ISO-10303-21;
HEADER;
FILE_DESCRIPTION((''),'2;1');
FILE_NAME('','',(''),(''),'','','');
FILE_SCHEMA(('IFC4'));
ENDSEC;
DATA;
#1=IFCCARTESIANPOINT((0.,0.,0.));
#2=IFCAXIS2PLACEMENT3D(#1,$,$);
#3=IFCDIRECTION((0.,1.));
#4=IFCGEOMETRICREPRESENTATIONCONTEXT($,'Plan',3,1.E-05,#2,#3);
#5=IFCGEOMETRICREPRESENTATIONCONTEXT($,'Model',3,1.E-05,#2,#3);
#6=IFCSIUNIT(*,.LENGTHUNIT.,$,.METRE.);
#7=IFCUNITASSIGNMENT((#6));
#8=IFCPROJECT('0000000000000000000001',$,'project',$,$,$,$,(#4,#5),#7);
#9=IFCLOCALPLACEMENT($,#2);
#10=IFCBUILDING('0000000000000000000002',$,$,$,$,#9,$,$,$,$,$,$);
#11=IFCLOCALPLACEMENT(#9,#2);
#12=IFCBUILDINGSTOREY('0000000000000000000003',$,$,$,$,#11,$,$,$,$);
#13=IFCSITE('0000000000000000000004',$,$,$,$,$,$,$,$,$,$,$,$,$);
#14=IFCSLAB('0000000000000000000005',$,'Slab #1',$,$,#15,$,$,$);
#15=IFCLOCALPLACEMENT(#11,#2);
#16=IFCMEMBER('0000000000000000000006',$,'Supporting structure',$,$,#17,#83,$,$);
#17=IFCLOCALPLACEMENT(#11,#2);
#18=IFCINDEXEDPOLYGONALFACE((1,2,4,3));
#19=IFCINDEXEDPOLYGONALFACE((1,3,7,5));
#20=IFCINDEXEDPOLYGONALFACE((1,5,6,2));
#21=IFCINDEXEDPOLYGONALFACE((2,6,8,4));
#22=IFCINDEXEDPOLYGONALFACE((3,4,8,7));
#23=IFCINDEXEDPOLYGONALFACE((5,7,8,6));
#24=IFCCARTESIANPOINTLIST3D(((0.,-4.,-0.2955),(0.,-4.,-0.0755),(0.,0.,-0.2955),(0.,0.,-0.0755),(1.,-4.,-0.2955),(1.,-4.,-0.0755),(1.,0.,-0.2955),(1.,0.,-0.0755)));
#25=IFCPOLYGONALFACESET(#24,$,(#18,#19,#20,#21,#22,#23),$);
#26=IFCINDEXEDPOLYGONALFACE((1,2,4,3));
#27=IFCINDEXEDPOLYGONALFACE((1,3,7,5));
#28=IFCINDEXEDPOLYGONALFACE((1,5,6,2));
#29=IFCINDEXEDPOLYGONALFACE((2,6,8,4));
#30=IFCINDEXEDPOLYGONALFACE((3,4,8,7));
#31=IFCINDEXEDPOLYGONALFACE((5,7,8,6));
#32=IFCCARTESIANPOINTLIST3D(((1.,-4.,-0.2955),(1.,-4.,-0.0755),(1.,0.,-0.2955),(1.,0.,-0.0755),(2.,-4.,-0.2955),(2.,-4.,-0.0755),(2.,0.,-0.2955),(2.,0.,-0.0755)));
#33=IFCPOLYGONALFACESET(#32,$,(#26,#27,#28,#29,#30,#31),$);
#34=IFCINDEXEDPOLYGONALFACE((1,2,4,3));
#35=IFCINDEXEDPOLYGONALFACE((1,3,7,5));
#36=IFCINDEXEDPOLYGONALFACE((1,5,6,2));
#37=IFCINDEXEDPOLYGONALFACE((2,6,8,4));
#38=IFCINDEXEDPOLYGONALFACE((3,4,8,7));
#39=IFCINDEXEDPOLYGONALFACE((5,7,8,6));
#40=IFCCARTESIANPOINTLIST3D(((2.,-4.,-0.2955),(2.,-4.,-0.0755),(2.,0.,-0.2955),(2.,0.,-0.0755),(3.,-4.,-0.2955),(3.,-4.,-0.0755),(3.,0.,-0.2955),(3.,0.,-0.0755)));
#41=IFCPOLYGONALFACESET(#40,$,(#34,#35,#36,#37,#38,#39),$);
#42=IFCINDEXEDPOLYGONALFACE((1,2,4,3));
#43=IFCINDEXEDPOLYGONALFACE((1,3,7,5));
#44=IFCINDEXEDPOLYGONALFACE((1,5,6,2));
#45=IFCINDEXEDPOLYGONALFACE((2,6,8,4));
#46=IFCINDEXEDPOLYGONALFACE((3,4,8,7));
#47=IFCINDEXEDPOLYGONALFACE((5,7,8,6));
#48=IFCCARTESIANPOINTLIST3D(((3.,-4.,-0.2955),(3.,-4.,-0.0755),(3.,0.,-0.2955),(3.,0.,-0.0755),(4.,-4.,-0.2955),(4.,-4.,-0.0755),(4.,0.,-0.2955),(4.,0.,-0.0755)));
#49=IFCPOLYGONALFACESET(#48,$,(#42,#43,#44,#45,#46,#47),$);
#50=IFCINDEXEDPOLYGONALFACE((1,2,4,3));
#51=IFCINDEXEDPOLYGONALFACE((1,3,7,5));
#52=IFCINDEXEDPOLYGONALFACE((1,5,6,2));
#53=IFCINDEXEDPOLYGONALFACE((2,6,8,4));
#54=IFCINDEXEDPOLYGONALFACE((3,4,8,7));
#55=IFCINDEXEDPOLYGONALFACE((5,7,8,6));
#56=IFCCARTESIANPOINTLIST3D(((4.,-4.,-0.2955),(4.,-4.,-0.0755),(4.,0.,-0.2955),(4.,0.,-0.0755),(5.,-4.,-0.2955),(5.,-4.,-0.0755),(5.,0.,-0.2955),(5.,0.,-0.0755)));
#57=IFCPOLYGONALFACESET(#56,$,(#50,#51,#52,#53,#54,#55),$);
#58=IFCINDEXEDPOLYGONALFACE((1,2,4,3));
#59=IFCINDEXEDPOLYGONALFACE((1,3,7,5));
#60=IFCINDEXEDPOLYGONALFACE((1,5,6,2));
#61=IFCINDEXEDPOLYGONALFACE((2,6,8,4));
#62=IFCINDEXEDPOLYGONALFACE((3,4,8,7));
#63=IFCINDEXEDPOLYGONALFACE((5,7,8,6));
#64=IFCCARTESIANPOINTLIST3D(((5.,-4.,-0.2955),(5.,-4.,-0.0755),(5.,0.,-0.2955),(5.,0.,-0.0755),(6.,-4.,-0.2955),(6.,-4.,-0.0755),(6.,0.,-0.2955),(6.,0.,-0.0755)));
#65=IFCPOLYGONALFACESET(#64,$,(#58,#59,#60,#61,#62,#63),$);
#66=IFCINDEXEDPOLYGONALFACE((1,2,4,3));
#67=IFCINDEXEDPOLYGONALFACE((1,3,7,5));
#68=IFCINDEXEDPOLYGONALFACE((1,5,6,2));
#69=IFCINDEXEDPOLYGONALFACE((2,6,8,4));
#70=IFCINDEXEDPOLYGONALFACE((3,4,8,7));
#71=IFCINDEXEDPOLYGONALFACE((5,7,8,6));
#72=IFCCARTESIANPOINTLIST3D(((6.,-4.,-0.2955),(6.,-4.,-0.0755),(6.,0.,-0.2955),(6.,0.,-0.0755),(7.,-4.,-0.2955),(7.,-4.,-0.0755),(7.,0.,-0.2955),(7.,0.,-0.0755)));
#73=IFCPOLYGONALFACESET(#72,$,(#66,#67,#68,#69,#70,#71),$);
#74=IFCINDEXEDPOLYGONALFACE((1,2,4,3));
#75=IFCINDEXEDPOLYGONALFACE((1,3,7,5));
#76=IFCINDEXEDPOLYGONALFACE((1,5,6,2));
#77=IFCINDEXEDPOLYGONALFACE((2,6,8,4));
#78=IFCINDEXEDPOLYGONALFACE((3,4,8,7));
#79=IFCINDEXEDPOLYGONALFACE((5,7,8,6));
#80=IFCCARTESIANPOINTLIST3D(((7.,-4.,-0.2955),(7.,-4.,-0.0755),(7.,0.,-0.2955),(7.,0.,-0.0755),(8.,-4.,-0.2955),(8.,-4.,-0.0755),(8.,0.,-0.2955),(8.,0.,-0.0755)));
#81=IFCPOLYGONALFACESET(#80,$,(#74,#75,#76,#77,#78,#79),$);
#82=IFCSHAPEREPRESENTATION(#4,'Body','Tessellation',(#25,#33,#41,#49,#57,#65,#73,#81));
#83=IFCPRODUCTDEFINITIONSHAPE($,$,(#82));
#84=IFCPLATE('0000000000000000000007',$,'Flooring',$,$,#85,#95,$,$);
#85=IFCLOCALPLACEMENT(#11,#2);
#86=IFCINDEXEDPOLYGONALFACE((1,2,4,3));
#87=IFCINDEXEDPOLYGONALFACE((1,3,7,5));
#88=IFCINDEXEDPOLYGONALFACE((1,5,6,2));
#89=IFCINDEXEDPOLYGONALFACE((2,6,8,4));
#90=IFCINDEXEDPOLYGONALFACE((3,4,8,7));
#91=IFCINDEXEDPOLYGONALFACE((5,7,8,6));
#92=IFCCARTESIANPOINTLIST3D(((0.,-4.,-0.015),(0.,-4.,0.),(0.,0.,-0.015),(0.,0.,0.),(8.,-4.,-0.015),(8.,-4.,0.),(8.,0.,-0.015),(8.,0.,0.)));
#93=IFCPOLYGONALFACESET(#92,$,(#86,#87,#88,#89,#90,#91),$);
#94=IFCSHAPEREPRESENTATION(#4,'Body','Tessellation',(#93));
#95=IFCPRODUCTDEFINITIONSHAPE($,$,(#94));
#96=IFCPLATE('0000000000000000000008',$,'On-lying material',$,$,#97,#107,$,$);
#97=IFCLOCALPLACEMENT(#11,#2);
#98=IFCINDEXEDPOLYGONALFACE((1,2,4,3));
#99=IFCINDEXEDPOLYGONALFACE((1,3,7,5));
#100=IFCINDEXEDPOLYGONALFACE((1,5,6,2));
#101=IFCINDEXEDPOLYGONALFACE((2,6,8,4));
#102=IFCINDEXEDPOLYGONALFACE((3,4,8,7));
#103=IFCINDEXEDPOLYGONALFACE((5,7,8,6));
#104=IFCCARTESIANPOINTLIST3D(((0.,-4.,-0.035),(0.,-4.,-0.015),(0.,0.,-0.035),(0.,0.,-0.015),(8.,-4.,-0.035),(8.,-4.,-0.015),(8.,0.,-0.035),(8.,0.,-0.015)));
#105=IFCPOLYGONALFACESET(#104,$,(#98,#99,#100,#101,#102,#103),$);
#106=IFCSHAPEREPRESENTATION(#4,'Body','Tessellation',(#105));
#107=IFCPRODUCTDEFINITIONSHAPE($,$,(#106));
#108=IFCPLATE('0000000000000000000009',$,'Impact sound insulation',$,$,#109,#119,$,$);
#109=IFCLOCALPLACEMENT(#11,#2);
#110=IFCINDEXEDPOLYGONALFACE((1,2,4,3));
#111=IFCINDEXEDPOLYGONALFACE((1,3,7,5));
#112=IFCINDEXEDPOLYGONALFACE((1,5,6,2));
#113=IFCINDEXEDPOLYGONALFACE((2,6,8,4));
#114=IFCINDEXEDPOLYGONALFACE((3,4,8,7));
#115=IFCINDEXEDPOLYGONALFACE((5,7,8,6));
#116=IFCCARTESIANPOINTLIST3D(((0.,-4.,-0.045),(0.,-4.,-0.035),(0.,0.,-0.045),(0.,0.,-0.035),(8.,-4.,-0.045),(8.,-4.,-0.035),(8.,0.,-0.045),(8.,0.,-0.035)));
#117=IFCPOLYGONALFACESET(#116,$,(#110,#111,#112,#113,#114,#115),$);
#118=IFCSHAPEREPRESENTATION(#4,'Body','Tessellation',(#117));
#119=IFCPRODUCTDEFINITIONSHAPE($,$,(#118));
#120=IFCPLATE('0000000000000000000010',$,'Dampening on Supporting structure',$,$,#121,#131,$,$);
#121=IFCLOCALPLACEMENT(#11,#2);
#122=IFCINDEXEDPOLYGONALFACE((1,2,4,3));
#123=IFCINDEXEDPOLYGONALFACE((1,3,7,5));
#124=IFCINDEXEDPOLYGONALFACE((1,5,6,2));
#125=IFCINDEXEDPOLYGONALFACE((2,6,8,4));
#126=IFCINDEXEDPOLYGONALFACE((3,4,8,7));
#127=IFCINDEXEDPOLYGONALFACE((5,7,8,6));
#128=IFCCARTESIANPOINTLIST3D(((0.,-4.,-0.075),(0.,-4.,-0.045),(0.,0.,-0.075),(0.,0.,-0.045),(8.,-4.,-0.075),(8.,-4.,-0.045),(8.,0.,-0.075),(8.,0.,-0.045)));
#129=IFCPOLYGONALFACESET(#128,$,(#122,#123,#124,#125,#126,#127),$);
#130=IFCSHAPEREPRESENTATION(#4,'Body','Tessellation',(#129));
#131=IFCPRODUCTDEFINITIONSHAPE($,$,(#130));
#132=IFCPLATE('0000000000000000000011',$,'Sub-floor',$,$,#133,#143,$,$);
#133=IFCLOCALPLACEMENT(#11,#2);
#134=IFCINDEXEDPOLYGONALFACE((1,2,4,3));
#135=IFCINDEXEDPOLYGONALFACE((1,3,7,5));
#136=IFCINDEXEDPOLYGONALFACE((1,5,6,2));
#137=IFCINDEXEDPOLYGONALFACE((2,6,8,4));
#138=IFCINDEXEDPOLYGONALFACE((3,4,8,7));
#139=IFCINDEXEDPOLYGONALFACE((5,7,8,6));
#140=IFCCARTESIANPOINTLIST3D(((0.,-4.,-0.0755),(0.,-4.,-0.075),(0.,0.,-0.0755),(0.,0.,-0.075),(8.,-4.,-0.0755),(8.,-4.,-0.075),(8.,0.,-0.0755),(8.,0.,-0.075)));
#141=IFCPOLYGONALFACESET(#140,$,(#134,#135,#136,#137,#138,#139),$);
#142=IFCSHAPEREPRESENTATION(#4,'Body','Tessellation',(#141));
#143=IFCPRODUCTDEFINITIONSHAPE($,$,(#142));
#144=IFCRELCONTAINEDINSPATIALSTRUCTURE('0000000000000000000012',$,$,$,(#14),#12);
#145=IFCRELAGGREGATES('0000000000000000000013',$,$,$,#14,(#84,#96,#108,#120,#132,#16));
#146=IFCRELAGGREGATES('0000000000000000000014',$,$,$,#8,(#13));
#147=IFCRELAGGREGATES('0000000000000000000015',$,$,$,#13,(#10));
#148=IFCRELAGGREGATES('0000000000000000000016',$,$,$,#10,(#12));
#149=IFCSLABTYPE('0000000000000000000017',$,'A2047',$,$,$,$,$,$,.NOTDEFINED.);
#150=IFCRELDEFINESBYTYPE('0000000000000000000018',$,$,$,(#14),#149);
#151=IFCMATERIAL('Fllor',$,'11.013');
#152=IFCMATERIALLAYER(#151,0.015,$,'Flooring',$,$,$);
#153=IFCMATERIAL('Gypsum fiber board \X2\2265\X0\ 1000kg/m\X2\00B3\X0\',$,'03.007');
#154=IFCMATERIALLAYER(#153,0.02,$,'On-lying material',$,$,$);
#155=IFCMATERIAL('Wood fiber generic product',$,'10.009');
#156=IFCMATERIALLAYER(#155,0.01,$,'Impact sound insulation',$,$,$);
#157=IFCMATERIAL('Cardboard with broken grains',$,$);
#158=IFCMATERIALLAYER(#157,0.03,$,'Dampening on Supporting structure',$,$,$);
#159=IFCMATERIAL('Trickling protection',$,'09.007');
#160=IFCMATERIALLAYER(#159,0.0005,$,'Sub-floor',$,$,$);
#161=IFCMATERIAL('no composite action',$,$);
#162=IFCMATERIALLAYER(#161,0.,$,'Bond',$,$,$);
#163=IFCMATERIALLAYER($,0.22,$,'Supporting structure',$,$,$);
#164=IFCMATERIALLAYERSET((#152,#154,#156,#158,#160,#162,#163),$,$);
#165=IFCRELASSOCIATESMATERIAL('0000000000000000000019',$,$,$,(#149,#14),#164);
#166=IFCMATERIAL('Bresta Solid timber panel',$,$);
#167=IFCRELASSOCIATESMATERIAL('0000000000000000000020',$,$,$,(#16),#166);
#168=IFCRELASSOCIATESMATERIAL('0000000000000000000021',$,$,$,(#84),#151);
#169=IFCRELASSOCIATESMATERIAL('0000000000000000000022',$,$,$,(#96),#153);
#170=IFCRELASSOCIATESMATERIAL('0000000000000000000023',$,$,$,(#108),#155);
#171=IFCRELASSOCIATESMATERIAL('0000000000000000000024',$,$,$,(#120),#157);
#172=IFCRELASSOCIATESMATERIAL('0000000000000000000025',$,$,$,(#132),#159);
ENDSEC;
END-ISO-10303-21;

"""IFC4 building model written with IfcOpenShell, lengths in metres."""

from ifc_helpers import new_model, si_unit, direction, frame, frame_2d, origin, origin_with_axes, place, context, project, spatial, rectangle, extrude, material, layer, layer_set, type_object, element, aggregate, save


model = new_model("IFC4")

# Units and contexts
plan_context = context("Plan", 3, precision=1e-05, world=origin(), true_north=direction((0.0, 1.0)))
model_context = context("Model", 3, precision=1e-05, world=origin(), true_north=direction((0.0, 1.0)))
ifc_project = project(units=[si_unit("LENGTHUNIT", "METRE")], contexts=[plan_context, model_context])

# Site, building, storey
site = spatial("IfcSite", under=ifc_project)
building_placement = place(None, origin())
building = spatial("IfcBuilding", under=site, at=building_placement)
storey_placement = place(building_placement, origin())
storey = spatial("IfcBuildingStorey", under=building, at=storey_placement)

# Slab, member, plates
ifc_material_1 = material(Name="Fllor", Category="11.013")
ifc_layer_1 = layer(ifc_material_1, 0.015, Name="Flooring")
ifc_material_2 = material(Name="Gypsum fiber board ≥ 1000kg/m³", Category="03.007")
ifc_layer_2 = layer(ifc_material_2, 0.02, Name="On-lying material")
ifc_material_3 = material(Name="Wood fiber generic product", Category="10.009")
ifc_layer_3 = layer(ifc_material_3, 0.01, Name="Impact sound insulation")
ifc_material_4 = material(Name="Cardboard with broken grains")
ifc_layer_4 = layer(ifc_material_4, 0.03, Name="Dampening on Supporting structure")
ifc_material_5 = material(Name="Trickling protection", Category="09.007")
ifc_layer_5 = layer(ifc_material_5, 0.0005, Name="Sub-floor")
ifc_material_6 = material(Name="no composite action")
ifc_layer_6 = layer(ifc_material_6, 0.0, Name="Bond")
ifc_layer_7 = layer(None, 0.22, Name="Supporting structure")
ifc_layer_set = layer_set([ifc_layer_1, ifc_layer_2, ifc_layer_3, ifc_layer_4, ifc_layer_5, ifc_layer_6, ifc_layer_7])
slab_type = type_object("IfcSlabType", Name="A2047", PredefinedType="NOTDEFINED", material=ifc_layer_set)
slab_placement = place(None, frame((0.0, 0.0, 0.0), z_axis=(0.0, 0.0, -1.0), x_axis=(1.0, 0.0, 0.0)))
slab = element("IfcSlab", 1, at=slab_placement, inside=storey, type_object=slab_type, material=ifc_layer_set, Name="Slab #1")
ifc_material_7 = material(Name="Bresta Solid timber panel")
member_placement = place(slab_placement, origin())
member = element("IfcMember", 2, at=member_placement, material=ifc_material_7, Name="Supporting structure", context=plan_context, shape_type="SweptSolid", body=[
    extrude(rectangle(XDim=1.0, YDim=0.22, at=frame_2d((0.5, 0.11), x_axis=(1.0, 0.0))), frame((0.0, 4.0, 0.0755), z_axis=(0.0, -1.0, 0.0), x_axis=(1.0, 0.0, 0.0)), (0.0, 0.0, 1.0), 4.0),
    extrude(rectangle(XDim=1.0, YDim=0.22, at=frame_2d((0.5, 0.11), x_axis=(1.0, 0.0))), frame((1.0, 4.0, 0.0755), z_axis=(0.0, -1.0, 0.0), x_axis=(1.0, 0.0, 0.0)), (0.0, 0.0, 1.0), 4.0),
    extrude(rectangle(XDim=1.0, YDim=0.22, at=frame_2d((0.5, 0.11), x_axis=(1.0, 0.0))), frame((2.0, 4.0, 0.0755), z_axis=(0.0, -1.0, 0.0), x_axis=(1.0, 0.0, 0.0)), (0.0, 0.0, 1.0), 4.0),
    extrude(rectangle(XDim=1.0, YDim=0.22, at=frame_2d((0.5, 0.11), x_axis=(1.0, 0.0))), frame((3.0, 4.0, 0.0755), z_axis=(0.0, -1.0, 0.0), x_axis=(1.0, 0.0, 0.0)), (0.0, 0.0, 1.0), 4.0),
    extrude(rectangle(XDim=1.0, YDim=0.22, at=frame_2d((0.5, 0.11), x_axis=(1.0, 0.0))), frame((4.0, 4.0, 0.0755), z_axis=(0.0, -1.0, 0.0), x_axis=(1.0, 0.0, 0.0)), (0.0, 0.0, 1.0), 4.0),
    extrude(rectangle(XDim=1.0, YDim=0.22, at=frame_2d((0.5, 0.11), x_axis=(1.0, 0.0))), frame((5.0, 4.0, 0.0755), z_axis=(0.0, -1.0, 0.0), x_axis=(1.0, 0.0, 0.0)), (0.0, 0.0, 1.0), 4.0),
    extrude(rectangle(XDim=1.0, YDim=0.22, at=frame_2d((0.5, 0.11), x_axis=(1.0, 0.0))), frame((6.0, 4.0, 0.0755), z_axis=(0.0, -1.0, 0.0), x_axis=(1.0, 0.0, 0.0)), (0.0, 0.0, 1.0), 4.0),
    extrude(rectangle(XDim=1.0, YDim=0.22, at=frame_2d((0.5, 0.11), x_axis=(1.0, 0.0))), frame((7.0, 4.0, 0.0755), z_axis=(0.0, -1.0, 0.0), x_axis=(1.0, 0.0, 0.0)), (0.0, 0.0, 1.0), 4.0),
])
plate_1_placement = place(slab_placement, origin())
plate_1 = element("IfcPlate", 3, at=plate_1_placement, material=ifc_material_1, Name="Flooring", context=plan_context, shape_type="SweptSolid", body=[
    extrude(rectangle(XDim=8.0, YDim=4.0, at=frame_2d((4.0, 2.0), x_axis=(1.0, 0.0))), origin_with_axes(), (0.0, 0.0, 1.0), 0.015),
])
plate_2_placement = place(slab_placement, origin())
plate_2 = element("IfcPlate", 4, at=plate_2_placement, material=ifc_material_2, Name="On-lying material", context=plan_context, shape_type="SweptSolid", body=[
    extrude(rectangle(XDim=8.0, YDim=4.0, at=frame_2d((4.0, 2.0), x_axis=(1.0, 0.0))), frame((0.0, 0.0, 0.015), z_axis=(0.0, 0.0, 1.0), x_axis=(1.0, 0.0, 0.0)), (0.0, 0.0, 1.0), 0.02),
])
plate_3_placement = place(slab_placement, origin())
plate_3 = element("IfcPlate", 5, at=plate_3_placement, material=ifc_material_3, Name="Impact sound insulation", context=plan_context, shape_type="SweptSolid", body=[
    extrude(rectangle(XDim=8.0, YDim=4.0, at=frame_2d((4.0, 2.0), x_axis=(1.0, 0.0))), frame((0.0, 0.0, 0.035), z_axis=(0.0, 0.0, 1.0), x_axis=(1.0, 0.0, 0.0)), (0.0, 0.0, 1.0), 0.01),
])
plate_4_placement = place(slab_placement, origin())
plate_4 = element("IfcPlate", 6, at=plate_4_placement, material=ifc_material_4, Name="Dampening on Supporting structure", context=plan_context, shape_type="SweptSolid", body=[
    extrude(rectangle(XDim=8.0, YDim=4.0, at=frame_2d((4.0, 2.0), x_axis=(1.0, 0.0))), frame((0.0, 0.0, 0.045), z_axis=(0.0, 0.0, 1.0), x_axis=(1.0, 0.0, 0.0)), (0.0, 0.0, 1.0), 0.03),
])
plate_5_placement = place(slab_placement, origin())
plate_5 = element("IfcPlate", 7, at=plate_5_placement, material=ifc_material_5, Name="Sub-floor", context=plan_context, shape_type="SweptSolid", body=[
    extrude(rectangle(XDim=8.0, YDim=4.0, at=frame_2d((4.0, 2.0), x_axis=(1.0, 0.0))), frame((0.0, 0.0, 0.075), z_axis=(0.0, 0.0, 1.0), x_axis=(1.0, 0.0, 0.0)), (0.0, 0.0, 1.0), 0.0005),
])
aggregate(slab, [plate_1, plate_2, plate_3, plate_4, plate_5, member])

save(model, "model.ifc")
